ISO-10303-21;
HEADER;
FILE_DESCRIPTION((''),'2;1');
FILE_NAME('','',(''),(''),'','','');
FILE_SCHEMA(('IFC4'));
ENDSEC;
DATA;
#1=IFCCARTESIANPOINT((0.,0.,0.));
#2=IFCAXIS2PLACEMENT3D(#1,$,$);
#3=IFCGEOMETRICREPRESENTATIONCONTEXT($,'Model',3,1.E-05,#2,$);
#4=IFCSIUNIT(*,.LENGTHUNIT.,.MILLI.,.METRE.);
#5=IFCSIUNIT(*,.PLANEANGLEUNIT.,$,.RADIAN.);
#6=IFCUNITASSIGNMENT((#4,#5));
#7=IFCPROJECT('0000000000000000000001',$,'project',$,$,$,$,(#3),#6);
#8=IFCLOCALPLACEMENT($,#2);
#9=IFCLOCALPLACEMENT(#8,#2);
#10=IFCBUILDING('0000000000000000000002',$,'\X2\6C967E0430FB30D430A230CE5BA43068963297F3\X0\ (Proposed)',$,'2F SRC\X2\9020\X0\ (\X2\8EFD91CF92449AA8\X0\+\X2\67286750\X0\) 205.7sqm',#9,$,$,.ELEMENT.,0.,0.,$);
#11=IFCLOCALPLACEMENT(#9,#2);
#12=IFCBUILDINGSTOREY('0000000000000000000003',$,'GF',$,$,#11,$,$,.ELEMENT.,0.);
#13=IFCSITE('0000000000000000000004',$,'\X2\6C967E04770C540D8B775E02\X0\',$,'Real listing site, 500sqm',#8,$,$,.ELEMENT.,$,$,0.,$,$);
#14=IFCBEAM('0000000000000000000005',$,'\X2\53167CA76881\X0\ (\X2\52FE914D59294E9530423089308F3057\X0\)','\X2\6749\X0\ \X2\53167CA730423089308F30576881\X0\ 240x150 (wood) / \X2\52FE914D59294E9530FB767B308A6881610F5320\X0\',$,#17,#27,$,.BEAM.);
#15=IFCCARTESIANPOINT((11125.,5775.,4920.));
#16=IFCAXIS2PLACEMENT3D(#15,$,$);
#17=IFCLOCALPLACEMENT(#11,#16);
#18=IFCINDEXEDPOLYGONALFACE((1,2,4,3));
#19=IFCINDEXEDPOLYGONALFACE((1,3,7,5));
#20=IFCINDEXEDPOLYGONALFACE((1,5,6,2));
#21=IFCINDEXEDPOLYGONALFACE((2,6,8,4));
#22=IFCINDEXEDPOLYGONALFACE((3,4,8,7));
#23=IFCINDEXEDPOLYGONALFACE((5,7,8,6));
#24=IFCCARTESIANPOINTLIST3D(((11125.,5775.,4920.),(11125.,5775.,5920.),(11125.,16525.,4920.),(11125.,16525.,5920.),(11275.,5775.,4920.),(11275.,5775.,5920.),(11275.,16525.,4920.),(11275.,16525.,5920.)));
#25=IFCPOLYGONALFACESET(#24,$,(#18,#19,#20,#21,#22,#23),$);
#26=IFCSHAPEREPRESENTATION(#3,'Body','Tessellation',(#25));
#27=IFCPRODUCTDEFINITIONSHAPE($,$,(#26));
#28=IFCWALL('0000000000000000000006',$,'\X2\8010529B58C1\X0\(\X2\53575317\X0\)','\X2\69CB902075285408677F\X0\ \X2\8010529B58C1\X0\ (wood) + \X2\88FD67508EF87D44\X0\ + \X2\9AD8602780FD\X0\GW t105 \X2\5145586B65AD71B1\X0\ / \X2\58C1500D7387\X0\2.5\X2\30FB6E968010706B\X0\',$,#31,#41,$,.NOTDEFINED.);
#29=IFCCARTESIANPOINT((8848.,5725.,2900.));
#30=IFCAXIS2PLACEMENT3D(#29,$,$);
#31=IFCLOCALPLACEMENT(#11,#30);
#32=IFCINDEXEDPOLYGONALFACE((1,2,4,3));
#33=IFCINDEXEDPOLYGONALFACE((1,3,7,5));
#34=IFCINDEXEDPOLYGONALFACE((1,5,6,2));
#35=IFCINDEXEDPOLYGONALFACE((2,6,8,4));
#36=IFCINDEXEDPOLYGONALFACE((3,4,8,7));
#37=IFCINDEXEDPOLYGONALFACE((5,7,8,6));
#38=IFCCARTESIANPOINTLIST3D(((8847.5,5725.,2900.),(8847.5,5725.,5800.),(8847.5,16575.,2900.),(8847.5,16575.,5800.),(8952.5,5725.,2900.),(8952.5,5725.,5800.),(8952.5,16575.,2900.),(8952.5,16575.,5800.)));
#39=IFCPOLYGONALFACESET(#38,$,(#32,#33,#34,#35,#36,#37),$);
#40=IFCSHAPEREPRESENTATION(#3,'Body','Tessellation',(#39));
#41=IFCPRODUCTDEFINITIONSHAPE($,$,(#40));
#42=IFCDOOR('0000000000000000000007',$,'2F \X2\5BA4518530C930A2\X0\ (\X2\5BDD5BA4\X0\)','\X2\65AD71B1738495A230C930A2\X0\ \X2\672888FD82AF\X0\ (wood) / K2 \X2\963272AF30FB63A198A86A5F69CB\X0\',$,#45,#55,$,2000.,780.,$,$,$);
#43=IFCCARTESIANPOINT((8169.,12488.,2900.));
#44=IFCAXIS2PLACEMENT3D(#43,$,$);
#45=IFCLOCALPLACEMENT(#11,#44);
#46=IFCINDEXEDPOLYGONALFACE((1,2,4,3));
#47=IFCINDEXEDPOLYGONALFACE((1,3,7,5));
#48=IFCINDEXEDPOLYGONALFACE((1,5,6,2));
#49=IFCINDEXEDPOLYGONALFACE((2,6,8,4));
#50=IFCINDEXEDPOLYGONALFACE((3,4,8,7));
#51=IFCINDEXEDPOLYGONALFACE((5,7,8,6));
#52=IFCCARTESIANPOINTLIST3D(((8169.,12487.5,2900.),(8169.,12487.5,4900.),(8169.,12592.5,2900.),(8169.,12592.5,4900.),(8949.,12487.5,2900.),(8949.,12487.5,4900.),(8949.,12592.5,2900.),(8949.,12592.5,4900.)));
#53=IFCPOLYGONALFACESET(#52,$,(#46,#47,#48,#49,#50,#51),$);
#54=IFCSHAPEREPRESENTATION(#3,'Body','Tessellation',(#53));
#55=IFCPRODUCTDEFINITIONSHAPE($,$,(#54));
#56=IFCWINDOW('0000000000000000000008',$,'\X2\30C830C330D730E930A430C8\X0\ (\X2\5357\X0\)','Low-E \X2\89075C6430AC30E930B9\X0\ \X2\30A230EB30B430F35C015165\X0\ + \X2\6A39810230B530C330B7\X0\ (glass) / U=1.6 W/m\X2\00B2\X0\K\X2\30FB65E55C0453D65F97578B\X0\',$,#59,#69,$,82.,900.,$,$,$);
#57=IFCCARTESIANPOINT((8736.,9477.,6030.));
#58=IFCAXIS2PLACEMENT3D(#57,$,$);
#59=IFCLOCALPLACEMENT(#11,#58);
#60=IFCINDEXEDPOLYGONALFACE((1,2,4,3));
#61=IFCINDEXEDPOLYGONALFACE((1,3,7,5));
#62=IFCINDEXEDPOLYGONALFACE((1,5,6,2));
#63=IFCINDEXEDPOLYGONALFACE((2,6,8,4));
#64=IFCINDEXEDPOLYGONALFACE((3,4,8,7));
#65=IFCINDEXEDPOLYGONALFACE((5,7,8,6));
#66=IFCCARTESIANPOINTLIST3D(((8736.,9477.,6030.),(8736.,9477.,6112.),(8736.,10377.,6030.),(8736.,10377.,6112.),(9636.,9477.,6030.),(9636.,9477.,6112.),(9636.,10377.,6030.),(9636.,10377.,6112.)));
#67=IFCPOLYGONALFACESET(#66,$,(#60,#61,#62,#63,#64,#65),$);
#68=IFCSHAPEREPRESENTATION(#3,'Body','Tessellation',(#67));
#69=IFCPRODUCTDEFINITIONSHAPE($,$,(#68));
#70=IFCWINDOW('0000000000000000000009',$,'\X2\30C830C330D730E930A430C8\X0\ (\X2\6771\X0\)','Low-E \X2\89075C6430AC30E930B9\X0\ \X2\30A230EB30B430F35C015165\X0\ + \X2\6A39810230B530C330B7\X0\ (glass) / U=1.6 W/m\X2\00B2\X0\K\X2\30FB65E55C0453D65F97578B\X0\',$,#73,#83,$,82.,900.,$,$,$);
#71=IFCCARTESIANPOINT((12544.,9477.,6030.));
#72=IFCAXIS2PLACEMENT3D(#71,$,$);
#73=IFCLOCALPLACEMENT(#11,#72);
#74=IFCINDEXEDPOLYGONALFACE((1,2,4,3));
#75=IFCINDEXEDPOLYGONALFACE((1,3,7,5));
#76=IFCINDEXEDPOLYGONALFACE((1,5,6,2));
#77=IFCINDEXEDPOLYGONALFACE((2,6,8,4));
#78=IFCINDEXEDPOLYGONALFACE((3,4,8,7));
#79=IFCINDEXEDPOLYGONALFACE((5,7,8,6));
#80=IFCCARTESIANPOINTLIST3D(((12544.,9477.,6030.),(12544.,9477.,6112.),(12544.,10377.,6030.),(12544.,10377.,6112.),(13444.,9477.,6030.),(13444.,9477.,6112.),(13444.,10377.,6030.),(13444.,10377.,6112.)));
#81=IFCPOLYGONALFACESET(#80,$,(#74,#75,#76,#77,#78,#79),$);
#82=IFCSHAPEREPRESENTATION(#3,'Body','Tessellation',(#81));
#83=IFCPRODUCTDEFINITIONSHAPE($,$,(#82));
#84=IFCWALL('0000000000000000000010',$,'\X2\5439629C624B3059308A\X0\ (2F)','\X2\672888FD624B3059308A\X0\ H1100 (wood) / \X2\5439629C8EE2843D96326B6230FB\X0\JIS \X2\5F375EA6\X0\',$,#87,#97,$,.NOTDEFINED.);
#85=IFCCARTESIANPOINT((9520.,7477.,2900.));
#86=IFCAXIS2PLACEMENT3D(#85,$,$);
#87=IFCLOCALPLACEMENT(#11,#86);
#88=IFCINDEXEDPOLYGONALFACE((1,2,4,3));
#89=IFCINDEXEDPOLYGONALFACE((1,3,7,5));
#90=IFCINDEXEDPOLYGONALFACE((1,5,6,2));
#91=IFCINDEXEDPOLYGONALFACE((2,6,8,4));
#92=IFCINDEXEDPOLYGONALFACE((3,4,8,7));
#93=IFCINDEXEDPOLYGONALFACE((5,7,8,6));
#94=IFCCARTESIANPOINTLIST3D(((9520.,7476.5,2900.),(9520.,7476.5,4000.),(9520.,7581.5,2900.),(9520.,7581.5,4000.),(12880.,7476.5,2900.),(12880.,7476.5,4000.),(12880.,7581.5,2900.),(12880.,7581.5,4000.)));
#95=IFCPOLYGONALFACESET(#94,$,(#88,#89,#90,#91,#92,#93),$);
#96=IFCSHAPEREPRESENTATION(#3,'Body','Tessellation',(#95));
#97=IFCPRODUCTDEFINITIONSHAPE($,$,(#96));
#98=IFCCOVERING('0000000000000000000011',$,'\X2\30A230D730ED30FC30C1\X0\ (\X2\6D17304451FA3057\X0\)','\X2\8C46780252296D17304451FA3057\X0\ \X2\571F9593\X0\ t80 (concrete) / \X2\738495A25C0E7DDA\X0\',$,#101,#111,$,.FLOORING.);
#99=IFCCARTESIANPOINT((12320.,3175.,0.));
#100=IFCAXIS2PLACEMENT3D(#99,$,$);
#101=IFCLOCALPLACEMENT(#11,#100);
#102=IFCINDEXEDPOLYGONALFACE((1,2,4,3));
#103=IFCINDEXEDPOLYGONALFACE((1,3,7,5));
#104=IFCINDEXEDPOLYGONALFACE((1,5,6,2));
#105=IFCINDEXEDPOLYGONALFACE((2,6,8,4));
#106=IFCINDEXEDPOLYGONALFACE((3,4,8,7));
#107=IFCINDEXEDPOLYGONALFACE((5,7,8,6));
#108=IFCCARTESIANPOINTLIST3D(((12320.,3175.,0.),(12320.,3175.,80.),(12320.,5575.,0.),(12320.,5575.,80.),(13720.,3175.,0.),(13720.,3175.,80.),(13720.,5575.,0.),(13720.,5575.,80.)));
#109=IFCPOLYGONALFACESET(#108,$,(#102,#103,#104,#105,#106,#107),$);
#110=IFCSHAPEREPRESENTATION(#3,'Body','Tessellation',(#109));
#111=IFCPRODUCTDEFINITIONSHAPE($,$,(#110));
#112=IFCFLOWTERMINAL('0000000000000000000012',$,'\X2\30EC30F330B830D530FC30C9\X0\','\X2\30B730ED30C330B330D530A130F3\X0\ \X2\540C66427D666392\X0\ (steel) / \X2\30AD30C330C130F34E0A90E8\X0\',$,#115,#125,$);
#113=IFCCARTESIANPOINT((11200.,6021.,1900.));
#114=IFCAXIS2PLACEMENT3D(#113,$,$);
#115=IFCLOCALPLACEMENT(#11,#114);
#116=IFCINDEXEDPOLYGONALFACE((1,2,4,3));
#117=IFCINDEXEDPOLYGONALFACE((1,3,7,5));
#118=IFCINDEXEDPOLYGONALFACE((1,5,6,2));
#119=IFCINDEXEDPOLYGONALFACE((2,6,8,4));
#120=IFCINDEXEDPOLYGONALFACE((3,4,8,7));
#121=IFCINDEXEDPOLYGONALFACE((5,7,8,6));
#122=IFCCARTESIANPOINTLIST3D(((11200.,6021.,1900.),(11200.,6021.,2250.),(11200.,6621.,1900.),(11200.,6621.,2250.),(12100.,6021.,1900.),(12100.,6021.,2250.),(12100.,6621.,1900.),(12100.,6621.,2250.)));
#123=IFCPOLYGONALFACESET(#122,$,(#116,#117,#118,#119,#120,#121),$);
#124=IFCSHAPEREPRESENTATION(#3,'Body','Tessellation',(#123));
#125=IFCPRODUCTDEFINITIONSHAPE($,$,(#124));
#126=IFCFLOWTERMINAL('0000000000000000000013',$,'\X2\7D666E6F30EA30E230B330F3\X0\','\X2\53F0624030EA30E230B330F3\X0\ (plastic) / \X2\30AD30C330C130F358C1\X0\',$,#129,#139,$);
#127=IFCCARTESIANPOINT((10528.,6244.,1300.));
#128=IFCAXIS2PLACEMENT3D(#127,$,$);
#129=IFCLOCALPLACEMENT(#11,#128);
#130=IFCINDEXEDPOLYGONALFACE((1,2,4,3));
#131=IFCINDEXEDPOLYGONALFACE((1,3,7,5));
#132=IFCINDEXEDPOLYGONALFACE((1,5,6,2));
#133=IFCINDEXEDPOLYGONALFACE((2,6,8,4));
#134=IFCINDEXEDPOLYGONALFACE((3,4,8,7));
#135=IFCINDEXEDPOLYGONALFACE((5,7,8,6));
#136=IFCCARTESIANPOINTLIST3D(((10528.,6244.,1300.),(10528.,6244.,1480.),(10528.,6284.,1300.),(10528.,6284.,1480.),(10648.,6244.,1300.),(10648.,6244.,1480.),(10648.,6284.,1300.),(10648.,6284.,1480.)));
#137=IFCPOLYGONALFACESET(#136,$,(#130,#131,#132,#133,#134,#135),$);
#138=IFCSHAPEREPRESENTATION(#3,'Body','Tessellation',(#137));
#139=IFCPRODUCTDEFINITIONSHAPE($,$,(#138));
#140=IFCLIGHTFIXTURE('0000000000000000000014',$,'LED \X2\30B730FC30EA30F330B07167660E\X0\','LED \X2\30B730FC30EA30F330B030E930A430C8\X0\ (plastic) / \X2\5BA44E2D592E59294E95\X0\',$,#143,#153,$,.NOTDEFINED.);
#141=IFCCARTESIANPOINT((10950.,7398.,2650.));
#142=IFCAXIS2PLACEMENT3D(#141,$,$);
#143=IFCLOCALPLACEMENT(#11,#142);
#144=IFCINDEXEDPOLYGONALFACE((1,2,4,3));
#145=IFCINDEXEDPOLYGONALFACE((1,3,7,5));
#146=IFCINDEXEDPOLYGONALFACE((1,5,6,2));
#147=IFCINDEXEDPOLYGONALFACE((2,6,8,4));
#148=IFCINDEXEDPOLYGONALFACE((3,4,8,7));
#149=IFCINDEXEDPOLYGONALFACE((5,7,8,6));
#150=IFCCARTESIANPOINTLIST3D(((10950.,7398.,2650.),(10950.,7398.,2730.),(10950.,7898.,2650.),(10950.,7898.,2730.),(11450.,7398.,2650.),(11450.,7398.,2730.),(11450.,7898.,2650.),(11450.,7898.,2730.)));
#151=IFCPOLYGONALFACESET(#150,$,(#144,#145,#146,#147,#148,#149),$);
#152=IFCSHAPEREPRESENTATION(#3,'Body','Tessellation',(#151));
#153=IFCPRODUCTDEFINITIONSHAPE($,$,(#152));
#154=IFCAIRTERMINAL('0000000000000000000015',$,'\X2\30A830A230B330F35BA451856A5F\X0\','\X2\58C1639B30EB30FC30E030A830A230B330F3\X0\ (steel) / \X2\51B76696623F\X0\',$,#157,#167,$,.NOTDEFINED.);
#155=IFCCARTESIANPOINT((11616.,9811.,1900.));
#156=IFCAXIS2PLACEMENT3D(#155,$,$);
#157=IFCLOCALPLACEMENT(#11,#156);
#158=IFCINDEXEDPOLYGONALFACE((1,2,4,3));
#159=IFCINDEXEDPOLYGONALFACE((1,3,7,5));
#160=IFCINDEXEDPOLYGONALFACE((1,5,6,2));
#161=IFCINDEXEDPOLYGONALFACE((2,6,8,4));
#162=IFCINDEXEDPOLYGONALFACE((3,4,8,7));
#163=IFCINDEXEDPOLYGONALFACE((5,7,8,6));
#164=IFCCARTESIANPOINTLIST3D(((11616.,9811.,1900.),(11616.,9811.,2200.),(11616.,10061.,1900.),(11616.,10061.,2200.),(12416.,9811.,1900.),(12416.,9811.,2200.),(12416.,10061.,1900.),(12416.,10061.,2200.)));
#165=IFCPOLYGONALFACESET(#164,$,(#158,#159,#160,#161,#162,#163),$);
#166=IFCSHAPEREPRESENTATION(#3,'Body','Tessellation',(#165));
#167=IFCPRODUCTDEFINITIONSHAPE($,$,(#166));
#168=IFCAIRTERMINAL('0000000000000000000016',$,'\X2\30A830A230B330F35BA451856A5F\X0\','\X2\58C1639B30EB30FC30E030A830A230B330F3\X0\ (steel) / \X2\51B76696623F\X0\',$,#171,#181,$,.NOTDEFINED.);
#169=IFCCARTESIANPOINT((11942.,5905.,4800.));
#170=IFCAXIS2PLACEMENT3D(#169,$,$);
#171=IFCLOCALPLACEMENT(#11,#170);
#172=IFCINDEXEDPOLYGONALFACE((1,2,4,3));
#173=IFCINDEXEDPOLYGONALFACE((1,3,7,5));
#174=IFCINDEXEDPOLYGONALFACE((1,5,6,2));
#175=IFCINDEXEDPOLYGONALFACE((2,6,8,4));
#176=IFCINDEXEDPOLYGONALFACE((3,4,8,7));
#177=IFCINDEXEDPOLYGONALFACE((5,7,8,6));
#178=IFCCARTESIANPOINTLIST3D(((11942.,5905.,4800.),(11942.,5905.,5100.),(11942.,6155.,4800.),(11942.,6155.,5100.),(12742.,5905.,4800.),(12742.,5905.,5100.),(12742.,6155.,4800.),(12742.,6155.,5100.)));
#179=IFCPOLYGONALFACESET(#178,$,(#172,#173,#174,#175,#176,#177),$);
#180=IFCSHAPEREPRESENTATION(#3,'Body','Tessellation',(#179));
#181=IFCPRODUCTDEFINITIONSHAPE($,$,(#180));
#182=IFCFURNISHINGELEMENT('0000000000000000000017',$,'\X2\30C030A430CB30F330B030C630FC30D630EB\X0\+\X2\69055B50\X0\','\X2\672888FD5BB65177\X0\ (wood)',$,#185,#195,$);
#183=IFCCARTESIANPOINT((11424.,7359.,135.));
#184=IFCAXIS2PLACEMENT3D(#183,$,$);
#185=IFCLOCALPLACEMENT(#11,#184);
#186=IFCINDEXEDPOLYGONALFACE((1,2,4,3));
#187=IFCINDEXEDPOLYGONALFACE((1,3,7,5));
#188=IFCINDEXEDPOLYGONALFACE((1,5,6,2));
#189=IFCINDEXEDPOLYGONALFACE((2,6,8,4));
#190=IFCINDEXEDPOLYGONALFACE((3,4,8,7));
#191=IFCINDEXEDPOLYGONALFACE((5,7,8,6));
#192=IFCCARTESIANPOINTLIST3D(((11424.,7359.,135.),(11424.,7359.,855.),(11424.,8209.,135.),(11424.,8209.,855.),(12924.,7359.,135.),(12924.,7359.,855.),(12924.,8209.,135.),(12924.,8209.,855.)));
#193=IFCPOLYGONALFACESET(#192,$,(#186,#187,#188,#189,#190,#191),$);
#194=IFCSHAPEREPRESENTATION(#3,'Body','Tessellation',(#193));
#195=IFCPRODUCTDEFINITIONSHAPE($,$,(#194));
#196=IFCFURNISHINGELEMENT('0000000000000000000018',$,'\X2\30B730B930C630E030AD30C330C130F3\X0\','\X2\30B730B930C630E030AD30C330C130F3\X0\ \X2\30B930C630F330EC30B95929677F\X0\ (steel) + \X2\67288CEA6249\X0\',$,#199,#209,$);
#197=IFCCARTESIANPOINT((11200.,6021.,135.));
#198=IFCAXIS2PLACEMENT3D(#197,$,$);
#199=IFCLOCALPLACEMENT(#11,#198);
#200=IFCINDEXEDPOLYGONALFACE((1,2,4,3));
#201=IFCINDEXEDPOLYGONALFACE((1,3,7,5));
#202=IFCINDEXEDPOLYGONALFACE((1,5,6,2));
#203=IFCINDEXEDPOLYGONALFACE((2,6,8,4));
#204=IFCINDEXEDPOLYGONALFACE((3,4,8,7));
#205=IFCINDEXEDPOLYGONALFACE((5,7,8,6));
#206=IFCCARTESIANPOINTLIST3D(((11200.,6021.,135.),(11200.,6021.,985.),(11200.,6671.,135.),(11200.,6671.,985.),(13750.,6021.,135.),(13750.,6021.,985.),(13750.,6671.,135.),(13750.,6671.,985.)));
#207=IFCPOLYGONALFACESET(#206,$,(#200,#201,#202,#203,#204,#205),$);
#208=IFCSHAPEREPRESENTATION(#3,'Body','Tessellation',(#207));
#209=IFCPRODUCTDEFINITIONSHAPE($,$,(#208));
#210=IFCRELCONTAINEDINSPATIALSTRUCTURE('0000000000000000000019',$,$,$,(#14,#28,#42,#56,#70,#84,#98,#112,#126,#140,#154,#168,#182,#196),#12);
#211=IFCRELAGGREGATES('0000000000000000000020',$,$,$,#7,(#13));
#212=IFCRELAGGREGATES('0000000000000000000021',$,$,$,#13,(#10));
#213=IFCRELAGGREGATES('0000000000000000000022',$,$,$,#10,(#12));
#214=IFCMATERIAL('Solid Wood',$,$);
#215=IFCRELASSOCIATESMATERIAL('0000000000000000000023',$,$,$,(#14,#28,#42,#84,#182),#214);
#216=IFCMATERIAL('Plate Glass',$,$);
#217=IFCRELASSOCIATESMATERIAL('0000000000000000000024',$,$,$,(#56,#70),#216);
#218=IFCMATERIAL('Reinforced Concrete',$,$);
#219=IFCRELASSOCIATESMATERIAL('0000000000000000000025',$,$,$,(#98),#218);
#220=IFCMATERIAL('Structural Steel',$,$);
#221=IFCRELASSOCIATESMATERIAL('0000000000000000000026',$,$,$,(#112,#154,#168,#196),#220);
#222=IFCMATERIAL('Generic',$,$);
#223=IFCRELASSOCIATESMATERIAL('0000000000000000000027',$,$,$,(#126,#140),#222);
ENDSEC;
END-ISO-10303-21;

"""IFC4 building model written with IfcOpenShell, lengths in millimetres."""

from ifc_helpers import new_model, si_unit, frame, frame_2d, origin, place, context, project, spatial, rectangle, extrude, material, element, fill, save


model = new_model("IFC4")

# Units and contexts
model_context = context("Model", 3, precision=1e-05, world=origin())
ifc_project = project(units=[si_unit("LENGTHUNIT", "METRE", prefix="MILLI"), si_unit("PLANEANGLEUNIT", "RADIAN")], contexts=[model_context])

# Site, building, storey
site_placement = place(None, origin())
site = spatial("IfcSite", under=ifc_project, at=site_placement, Name="沖縄県名護市", ObjectType="Real listing site, 500sqm", CompositionType="ELEMENT", RefElevation=0.0)
building_placement = place(site_placement, origin())
building = spatial("IfcBuilding", under=site, at=building_placement, Name="沖縄・ピアノ室と防音 (Proposed)", ObjectType="2F SRC造 (軽量鉄骨+木材) 205.7sqm", CompositionType="ELEMENT", ElevationOfRefHeight=0.0, ElevationOfTerrain=0.0)
storey_placement = place(building_placement, origin())
storey = spatial("IfcBuildingStorey", under=building, at=storey_placement, Name="GF", CompositionType="ELEMENT", Elevation=0.0)

# Shared definitions
ifc_material_1 = material(Name="Solid Wood")

# Beam
beam_placement = place(storey_placement, frame((11125.0, 5775.0, 4920.0)))
element("IfcBeam", 1, at=beam_placement, inside=storey, material=ifc_material_1, Name="化粧梁 (勾配天井あらわし)", Description="杉 化粧あらわし梁 240x150 (wood) / 勾配天井・登り梁意匠", PredefinedType="BEAM", context=model_context, shape_type="SweptSolid", body=[
    extrude(rectangle(XDim=150.0, YDim=10750.0, at=frame_2d((75.0, 5375.0))), frame((11125.0, 5775.0, 4920.0)), (0.0, 0.0, 1.0), 1000.0),
])

# Wall, opening, door
wall_1_placement = place(storey_placement, frame((8848.0, 5725.0, 2900.0)))
wall_1 = element("IfcWall", 2, at=wall_1_placement, inside=storey, material=ifc_material_1, Name="耐力壁(南北)", Description="構造用合板 耐力壁 (wood) + 製材軸組 + 高性能GW t105 充填断熱 / 壁倍率2.5・準耐火", PredefinedType="NOTDEFINED", context=model_context, shape_type="SweptSolid", body=[
    extrude(rectangle(XDim=105.0, YDim=10850.0, at=frame_2d((52.0, 5425.0))), frame((8848.0, 5725.0, 2900.0)), (0.0, 0.0, 1.0), 2900.0),
])
opening_1_placement = place(storey_placement, frame((8169.0, 12488.0, 2900.0)))
opening_1 = element("IfcOpeningElement", 3, at=opening_1_placement, cuts=wall_1, PredefinedType="NOTDEFINED", context=model_context, shape_type="SweptSolid", body=[
    extrude(rectangle(XDim=780.0, YDim=105.0, at=frame_2d((390.0, 52.0))), frame((8169.0, 12488.0, 2900.0)), (0.0, 0.0, 1.0), 2000.0),
])
door_1_placement = place(storey_placement, frame((8169.0, 12488.0, 2900.0)))
door_1 = element("IfcDoor", 4, at=door_1_placement, inside=storey, material=ifc_material_1, Name="2F 室内ドア (寝室)", Description="断熱玄関ドア 木製芯 (wood) / K2 防犯・採風機構", OverallHeight=2000.0, OverallWidth=780.0, context=model_context, shape_type="SweptSolid", body=[
    extrude(rectangle(XDim=780.0, YDim=105.0, at=frame_2d((390.0, 52.0))), frame((8169.0, 12488.0, 2900.0)), (0.0, 0.0, 1.0), 2000.0),
])
fill(opening_1, door_1)

# Windows
ifc_material_2 = material(Name="Plate Glass")
window_1_placement = place(storey_placement, frame((8736.0, 9477.0, 6030.0)))
element("IfcWindow", 5, at=window_1_placement, inside=storey, material=ifc_material_2, Name="トップライト (南)", Description="Low-E 複層ガラス アルゴン封入 + 樹脂サッシ (glass) / U=1.6 W/m²K・日射取得型", OverallHeight=82.0, OverallWidth=900.0, context=model_context, shape_type="SweptSolid", body=[
    extrude(rectangle(XDim=900.0, YDim=900.0, at=frame_2d((450.0, 450.0))), frame((8736.0, 9477.0, 6030.0)), (0.0, 0.0, 1.0), 82.0),
])
window_2_placement = place(storey_placement, frame((12544.0, 9477.0, 6030.0)))
element("IfcWindow", 6, at=window_2_placement, inside=storey, material=ifc_material_2, Name="トップライト (東)", Description="Low-E 複層ガラス アルゴン封入 + 樹脂サッシ (glass) / U=1.6 W/m²K・日射取得型", OverallHeight=82.0, OverallWidth=900.0, context=model_context, shape_type="SweptSolid", body=[
    extrude(rectangle(XDim=900.0, YDim=900.0, at=frame_2d((450.0, 450.0))), frame((12544.0, 9477.0, 6030.0)), (0.0, 0.0, 1.0), 82.0),
])

# Wall
wall_2_placement = place(storey_placement, frame((9520.0, 7477.0, 2900.0)))
element("IfcWall", 7, at=wall_2_placement, inside=storey, material=ifc_material_1, Name="吹抜手すり (2F)", Description="木製手すり H1100 (wood) / 吹抜転落防止・JIS 強度", PredefinedType="NOTDEFINED", context=model_context, shape_type="SweptSolid", body=[
    extrude(rectangle(XDim=3360.0, YDim=105.0, at=frame_2d((1680.0, 52.0))), frame((9520.0, 7477.0, 2900.0)), (0.0, 0.0, 1.0), 1100.0),
])

# Covering
ifc_material_3 = material(Name="Reinforced Concrete")
covering_placement = place(storey_placement, frame((12320.0, 3175.0, 0.0)))
element("IfcCovering", 8, at=covering_placement, inside=storey, material=ifc_material_3, Name="アプローチ (洗い出し)", Description="豆砂利洗い出し 土間 t80 (concrete) / 玄関導線", PredefinedType="FLOORING", context=model_context, shape_type="SweptSolid", body=[
    extrude(rectangle(XDim=1400.0, YDim=2400.0, at=frame_2d((700.0, 1200.0))), frame((12320.0, 3175.0, 0.0)), (0.0, 0.0, 1.0), 80.0),
])

# Flow terminals
ifc_material_4 = material(Name="Structural Steel")
flow_terminal_1_placement = place(storey_placement, frame((11200.0, 6021.0, 1900.0)))
element("IfcFlowTerminal", 9, at=flow_terminal_1_placement, inside=storey, material=ifc_material_4, Name="レンジフード", Description="シロッコファン 同時給排 (steel) / キッチン上部", context=model_context, shape_type="SweptSolid", body=[
    extrude(rectangle(XDim=900.0, YDim=600.0, at=frame_2d((450.0, 300.0))), frame((11200.0, 6021.0, 1900.0)), (0.0, 0.0, 1.0), 350.0),
])
ifc_material_5 = material(Name="Generic")
flow_terminal_2_placement = place(storey_placement, frame((10528.0, 6244.0, 1300.0)))
element("IfcFlowTerminal", 10, at=flow_terminal_2_placement, inside=storey, material=ifc_material_5, Name="給湯リモコン", Description="台所リモコン (plastic) / キッチン壁", context=model_context, shape_type="SweptSolid", body=[
    extrude(rectangle(XDim=120.0, YDim=40.0, at=frame_2d((60.0, 20.0))), frame((10528.0, 6244.0, 1300.0)), (0.0, 0.0, 1.0), 180.0),
])

# Light fixture
light_fixture_placement = place(storey_placement, frame((10950.0, 7398.0, 2650.0)))
element("IfcLightFixture", 11, at=light_fixture_placement, inside=storey, material=ifc_material_5, Name="LED シーリング照明", Description="LED シーリングライト (plastic) / 室中央天井", PredefinedType="NOTDEFINED", context=model_context, shape_type="SweptSolid", body=[
    extrude(rectangle(XDim=500.0, YDim=500.0, at=frame_2d((250.0, 250.0))), frame((10950.0, 7398.0, 2650.0)), (0.0, 0.0, 1.0), 80.0),
])

# Air terminals
air_terminal_1_placement = place(storey_placement, frame((11616.0, 9811.0, 1900.0)))
element("IfcAirTerminal", 12, at=air_terminal_1_placement, inside=storey, material=ifc_material_4, Name="エアコン室内機", Description="壁掛ルームエアコン (steel) / 冷暖房", PredefinedType="NOTDEFINED", context=model_context, shape_type="SweptSolid", body=[
    extrude(rectangle(XDim=800.0, YDim=250.0, at=frame_2d((400.0, 125.0))), frame((11616.0, 9811.0, 1900.0)), (0.0, 0.0, 1.0), 300.0),
])
air_terminal_2_placement = place(storey_placement, frame((11942.0, 5905.0, 4800.0)))
element("IfcAirTerminal", 13, at=air_terminal_2_placement, inside=storey, material=ifc_material_4, Name="エアコン室内機", Description="壁掛ルームエアコン (steel) / 冷暖房", PredefinedType="NOTDEFINED", context=model_context, shape_type="SweptSolid", body=[
    extrude(rectangle(XDim=800.0, YDim=250.0, at=frame_2d((400.0, 125.0))), frame((11942.0, 5905.0, 4800.0)), (0.0, 0.0, 1.0), 300.0),
])

# Furnishing elements
furnishing_1_placement = place(storey_placement, frame((11424.0, 7359.0, 135.0)))
element("IfcFurnishingElement", 14, at=furnishing_1_placement, inside=storey, material=ifc_material_1, Name="ダイニングテーブル+椅子", Description="木製家具 (wood)", context=model_context, shape_type="SweptSolid", body=[
    extrude(rectangle(XDim=1500.0, YDim=850.0, at=frame_2d((750.0, 425.0))), frame((11424.0, 7359.0, 135.0)), (0.0, 0.0, 1.0), 720.0),
])
furnishing_2_placement = place(storey_placement, frame((11200.0, 6021.0, 135.0)))
element("IfcFurnishingElement", 15, at=furnishing_2_placement, inside=storey, material=ifc_material_4, Name="システムキッチン", Description="システムキッチン ステンレス天板 (steel) + 木質扉", context=model_context, shape_type="SweptSolid", body=[
    extrude(rectangle(XDim=2550.0, YDim=650.0, at=frame_2d((1275.0, 325.0))), frame((11200.0, 6021.0, 135.0)), (0.0, 0.0, 1.0), 850.0),
])

save(model, "model.ifc")
